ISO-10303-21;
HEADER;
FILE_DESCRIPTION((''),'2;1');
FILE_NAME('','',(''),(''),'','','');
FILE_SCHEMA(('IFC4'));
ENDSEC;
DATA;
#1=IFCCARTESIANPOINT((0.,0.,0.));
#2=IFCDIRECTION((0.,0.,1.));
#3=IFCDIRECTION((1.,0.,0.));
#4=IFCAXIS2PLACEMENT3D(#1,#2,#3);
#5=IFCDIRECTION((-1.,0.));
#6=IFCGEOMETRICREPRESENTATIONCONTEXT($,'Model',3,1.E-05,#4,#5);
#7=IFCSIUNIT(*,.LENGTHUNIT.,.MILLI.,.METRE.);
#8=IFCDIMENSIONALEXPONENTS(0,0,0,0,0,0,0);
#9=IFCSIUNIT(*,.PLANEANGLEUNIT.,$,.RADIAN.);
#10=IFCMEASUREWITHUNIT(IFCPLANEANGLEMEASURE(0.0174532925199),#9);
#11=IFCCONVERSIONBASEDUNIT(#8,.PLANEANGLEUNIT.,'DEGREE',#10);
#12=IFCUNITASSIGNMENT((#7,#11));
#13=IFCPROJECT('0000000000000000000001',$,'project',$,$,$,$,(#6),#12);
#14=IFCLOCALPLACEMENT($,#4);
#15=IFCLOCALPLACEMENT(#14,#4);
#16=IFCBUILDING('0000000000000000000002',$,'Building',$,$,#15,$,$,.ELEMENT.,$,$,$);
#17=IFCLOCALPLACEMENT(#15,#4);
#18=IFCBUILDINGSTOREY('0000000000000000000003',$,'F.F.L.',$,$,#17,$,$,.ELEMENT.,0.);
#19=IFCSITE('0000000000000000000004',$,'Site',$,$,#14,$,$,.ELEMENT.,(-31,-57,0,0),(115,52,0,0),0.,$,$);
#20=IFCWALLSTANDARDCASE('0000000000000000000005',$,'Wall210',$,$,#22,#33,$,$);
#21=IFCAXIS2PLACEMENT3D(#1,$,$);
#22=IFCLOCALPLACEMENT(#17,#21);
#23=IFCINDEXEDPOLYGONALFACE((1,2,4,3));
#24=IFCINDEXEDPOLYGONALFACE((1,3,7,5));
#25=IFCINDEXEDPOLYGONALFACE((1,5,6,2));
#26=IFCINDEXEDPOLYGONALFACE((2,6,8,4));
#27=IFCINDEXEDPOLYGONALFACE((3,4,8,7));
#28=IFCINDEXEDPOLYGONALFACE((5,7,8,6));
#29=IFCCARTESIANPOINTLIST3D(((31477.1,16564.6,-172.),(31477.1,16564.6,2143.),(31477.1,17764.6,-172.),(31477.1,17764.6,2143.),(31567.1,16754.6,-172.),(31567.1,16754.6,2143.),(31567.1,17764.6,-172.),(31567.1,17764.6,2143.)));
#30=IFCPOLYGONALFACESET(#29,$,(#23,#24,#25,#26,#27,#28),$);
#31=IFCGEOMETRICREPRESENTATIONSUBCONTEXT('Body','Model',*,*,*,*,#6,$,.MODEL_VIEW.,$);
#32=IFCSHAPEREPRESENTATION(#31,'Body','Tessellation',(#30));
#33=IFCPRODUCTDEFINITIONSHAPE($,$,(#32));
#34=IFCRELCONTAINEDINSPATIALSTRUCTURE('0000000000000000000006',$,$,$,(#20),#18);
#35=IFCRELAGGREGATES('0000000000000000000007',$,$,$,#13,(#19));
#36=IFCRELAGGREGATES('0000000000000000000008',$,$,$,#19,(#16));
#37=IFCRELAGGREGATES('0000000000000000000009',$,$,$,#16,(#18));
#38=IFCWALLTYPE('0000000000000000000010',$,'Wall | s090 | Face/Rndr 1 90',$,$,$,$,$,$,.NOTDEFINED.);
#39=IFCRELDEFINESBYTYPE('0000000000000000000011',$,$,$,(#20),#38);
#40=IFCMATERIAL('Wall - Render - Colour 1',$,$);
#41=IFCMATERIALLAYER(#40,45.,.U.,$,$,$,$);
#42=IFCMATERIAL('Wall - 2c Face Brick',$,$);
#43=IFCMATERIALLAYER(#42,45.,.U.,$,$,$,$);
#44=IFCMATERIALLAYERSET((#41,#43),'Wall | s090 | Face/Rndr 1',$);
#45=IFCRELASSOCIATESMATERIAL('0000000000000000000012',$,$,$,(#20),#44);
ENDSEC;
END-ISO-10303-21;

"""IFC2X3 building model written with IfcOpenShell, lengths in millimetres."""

from ifc_helpers import new_model, entity, si_unit, converted_unit, direction, frame, origin_with_axes, place, context, subcontext, project, spatial, polyline, outline, extrude, material, layer, layer_set, layer_usage, type_object, element, save


model = new_model("IFC2X3")

# Units and contexts
model_context = context("Model", 3, precision=1e-05, world=origin_with_axes(), true_north=direction((-1.0, 0.0)))
body_context = subcontext(model_context, "Body", "Model", "MODEL_VIEW")
ifc_project = project(units=[si_unit("LENGTHUNIT", "METRE", prefix="MILLI"), converted_unit("PLANEANGLEUNIT", "DEGREE", entity("IfcPlaneAngleMeasure", 0.0174532925199), si_unit("PLANEANGLEUNIT", "RADIAN"), dimensions=[0, 0, 0, 0, 0, 0, 0])], contexts=[model_context])

# Site, building, storey
site_placement = place(None, origin_with_axes())
site = spatial("IfcSite", under=ifc_project, at=site_placement, Name="Site", CompositionType="ELEMENT", RefLatitude=(-31, -57, 0, 0), RefLongitude=(115, 52, 0, 0), RefElevation=0.0)
building_placement = place(site_placement, origin_with_axes())
building = spatial("IfcBuilding", under=site, at=building_placement, Name="Building", CompositionType="ELEMENT")
storey_placement = place(building_placement, origin_with_axes())
storey = spatial("IfcBuildingStorey", under=building, at=storey_placement, Name="F.F.L.", CompositionType="ELEMENT", Elevation=0.0)

# Shared definitions
ifc_material_1 = material(Name="Wall - 2c Face Brick")

# Shared definitions
ifc_material_2 = material(Name="Wall - Render - Colour 1")

# Wall
ifc_layer_1 = layer(ifc_material_2, 45.0, ventilated="UNKNOWN")
ifc_layer_2 = layer(ifc_material_1, 45.0, ventilated="UNKNOWN")
ifc_layer_set_1 = layer_set([ifc_layer_1, ifc_layer_2], Name="Wall | s090 | Face/Rndr 1")
ifc_layer_usage_1 = layer_usage(ifc_layer_set_1, "AXIS2", "NEGATIVE", 0.0)
wall_type_1 = type_object("IfcWallType", Name="Wall | s090 | Face/Rndr 1 90", PredefinedType="NOTDEFINED")
wall_1_placement = place(storey_placement, frame((31477.1, 16564.6, -172.0), z_axis=(0.0, 0.0, 1.0), x_axis=(0.0, 1.0, 0.0)))
element("IfcWallStandardCase", 1, at=wall_1_placement, inside=storey, type_object=wall_type_1, material=ifc_layer_usage_1, Name="Wall210", context=body_context, shape_type="SweptSolid", body=[
    extrude(outline(polyline([(190.0, -90.0), (1200.0, -90.0), (1200.0, 0.0), (0.0, 0.0), (190.0, -90.0)])), origin_with_axes(), (0.0, 0.0, 1.0), 2315.0),
])

save(model, "model.ifc")
